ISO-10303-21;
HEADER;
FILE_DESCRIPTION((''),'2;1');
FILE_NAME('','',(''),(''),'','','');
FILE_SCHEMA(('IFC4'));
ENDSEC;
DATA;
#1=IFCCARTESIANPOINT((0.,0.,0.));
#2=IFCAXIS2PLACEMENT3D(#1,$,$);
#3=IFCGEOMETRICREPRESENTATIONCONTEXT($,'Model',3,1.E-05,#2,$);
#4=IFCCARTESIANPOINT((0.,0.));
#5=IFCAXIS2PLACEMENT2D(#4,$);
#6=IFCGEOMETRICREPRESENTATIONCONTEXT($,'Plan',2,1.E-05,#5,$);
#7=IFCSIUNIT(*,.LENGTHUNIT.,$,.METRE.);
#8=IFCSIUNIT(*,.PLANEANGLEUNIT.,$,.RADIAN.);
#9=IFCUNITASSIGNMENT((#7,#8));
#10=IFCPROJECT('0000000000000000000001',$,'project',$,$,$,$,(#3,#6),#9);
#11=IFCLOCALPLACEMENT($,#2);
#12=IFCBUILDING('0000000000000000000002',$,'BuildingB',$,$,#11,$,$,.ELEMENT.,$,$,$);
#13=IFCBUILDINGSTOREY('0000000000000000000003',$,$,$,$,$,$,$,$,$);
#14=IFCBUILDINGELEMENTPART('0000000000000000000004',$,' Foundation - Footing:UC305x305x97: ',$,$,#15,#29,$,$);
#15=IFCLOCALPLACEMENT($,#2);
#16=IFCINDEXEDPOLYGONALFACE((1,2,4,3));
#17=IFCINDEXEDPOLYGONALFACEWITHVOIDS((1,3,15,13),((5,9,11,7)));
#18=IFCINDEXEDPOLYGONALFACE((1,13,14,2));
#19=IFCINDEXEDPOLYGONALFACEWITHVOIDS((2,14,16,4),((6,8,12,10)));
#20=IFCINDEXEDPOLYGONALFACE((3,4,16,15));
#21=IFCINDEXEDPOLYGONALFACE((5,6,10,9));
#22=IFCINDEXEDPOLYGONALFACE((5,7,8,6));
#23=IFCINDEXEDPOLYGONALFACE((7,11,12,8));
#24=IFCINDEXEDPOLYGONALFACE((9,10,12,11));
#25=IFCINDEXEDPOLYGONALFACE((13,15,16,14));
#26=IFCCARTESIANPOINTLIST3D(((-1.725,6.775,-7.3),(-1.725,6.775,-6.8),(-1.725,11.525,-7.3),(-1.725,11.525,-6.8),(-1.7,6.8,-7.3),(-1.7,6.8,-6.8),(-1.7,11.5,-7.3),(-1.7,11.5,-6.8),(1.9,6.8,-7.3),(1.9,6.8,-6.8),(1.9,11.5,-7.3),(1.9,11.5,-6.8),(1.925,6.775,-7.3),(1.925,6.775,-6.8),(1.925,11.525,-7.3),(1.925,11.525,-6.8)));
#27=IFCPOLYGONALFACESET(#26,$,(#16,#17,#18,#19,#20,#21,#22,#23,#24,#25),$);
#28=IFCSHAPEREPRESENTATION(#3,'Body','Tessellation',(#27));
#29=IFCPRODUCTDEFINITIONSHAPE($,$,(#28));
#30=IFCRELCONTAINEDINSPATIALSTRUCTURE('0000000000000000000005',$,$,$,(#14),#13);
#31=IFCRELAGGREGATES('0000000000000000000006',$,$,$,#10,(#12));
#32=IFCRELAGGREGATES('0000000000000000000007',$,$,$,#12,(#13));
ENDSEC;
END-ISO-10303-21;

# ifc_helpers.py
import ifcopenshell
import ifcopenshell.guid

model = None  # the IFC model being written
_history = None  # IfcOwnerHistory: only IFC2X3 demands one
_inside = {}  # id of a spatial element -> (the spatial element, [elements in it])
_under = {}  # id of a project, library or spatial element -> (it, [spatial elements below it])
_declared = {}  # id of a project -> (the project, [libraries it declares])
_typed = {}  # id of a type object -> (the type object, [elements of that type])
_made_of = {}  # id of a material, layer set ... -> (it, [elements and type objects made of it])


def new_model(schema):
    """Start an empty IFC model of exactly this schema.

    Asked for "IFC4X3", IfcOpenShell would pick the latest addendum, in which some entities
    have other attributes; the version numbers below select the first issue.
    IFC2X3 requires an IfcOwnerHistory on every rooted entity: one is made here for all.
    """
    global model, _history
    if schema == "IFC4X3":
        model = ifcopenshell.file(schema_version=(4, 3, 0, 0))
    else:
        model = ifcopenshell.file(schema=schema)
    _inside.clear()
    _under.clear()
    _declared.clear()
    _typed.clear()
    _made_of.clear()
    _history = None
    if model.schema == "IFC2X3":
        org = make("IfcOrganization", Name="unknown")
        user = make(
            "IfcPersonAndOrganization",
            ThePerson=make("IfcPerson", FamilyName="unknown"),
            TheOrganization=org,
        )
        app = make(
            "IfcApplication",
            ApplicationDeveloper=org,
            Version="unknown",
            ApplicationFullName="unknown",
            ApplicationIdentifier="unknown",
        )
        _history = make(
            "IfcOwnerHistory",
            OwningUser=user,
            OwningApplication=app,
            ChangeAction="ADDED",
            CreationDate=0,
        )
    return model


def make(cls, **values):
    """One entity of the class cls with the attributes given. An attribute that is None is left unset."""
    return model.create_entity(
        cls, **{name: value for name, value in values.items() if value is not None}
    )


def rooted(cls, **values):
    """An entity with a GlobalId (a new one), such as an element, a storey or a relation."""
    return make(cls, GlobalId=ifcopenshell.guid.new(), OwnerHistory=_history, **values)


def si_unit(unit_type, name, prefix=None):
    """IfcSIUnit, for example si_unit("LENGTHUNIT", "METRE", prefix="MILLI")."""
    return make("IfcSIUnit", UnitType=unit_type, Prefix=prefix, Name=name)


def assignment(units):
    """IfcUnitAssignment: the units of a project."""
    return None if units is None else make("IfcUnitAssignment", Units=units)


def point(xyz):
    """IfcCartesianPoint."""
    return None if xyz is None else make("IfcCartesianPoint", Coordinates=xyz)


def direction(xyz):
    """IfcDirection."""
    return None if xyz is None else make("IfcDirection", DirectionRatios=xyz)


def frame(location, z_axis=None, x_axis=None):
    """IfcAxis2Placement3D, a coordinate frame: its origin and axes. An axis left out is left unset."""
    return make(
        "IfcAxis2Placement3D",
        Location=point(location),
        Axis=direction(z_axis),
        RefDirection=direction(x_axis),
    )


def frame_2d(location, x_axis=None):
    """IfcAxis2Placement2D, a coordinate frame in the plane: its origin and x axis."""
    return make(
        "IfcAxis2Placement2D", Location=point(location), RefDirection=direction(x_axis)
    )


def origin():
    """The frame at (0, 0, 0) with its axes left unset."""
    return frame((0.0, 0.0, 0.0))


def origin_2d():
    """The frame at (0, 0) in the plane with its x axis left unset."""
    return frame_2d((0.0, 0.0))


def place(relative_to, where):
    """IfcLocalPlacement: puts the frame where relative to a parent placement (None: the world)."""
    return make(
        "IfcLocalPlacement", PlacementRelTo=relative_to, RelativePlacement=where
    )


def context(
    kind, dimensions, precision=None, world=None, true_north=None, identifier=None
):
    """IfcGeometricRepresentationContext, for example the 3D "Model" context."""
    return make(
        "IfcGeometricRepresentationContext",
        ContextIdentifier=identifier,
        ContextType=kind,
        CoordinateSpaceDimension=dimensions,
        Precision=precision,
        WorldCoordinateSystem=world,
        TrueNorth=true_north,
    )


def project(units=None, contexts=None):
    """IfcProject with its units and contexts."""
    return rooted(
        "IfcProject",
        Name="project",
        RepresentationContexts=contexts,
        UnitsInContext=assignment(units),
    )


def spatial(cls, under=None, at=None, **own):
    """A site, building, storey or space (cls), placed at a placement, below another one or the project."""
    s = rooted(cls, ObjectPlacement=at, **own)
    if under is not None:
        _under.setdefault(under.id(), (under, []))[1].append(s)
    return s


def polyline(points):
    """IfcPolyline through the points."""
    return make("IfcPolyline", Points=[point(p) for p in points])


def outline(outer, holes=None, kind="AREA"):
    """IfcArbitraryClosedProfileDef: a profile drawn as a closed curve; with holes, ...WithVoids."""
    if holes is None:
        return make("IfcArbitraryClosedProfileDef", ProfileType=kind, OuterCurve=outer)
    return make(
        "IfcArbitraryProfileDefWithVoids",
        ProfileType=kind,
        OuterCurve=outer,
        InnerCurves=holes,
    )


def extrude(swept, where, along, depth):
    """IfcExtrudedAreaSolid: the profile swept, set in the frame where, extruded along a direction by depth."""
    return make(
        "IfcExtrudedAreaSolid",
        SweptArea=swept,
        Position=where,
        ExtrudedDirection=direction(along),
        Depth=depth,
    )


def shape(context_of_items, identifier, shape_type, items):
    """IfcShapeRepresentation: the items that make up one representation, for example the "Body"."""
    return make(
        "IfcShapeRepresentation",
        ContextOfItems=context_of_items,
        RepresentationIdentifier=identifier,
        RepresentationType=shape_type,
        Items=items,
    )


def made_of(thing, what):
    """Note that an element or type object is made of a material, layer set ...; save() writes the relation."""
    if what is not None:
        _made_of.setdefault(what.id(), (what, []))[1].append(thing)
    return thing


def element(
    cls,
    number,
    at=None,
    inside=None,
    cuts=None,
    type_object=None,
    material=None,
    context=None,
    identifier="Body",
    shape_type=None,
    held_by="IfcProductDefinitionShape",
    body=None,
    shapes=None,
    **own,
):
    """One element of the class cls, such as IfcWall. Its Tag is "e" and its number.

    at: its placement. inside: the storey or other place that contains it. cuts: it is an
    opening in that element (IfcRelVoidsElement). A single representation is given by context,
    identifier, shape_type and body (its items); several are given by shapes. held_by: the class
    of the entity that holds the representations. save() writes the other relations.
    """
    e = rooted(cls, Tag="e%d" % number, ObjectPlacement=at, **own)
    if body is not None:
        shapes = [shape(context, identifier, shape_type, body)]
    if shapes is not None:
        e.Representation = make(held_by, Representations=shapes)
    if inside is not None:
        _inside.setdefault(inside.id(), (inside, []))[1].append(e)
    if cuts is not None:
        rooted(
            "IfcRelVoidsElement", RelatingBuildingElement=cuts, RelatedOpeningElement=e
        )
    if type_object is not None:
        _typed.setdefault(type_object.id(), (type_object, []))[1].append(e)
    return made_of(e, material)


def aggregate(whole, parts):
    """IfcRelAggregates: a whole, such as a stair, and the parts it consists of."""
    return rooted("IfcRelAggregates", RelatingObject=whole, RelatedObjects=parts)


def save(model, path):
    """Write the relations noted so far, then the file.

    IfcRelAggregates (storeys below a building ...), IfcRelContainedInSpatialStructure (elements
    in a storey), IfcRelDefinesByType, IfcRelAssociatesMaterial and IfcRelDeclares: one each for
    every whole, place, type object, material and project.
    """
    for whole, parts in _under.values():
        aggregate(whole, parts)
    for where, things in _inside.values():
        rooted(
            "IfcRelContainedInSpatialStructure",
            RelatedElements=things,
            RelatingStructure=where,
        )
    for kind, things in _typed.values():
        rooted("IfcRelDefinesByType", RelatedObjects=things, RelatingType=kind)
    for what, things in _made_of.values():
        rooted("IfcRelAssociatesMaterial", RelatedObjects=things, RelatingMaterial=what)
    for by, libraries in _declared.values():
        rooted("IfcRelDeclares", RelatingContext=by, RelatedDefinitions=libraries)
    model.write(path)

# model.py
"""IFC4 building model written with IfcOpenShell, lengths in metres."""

from ifc_helpers import new_model, si_unit, origin, origin_2d, place, context, project, spatial, polyline, outline, extrude, element, save


model = new_model("IFC4")

# Units and contexts
model_context = context("Model", 3, precision=1e-05, world=origin())
plan_context = context("Plan", 2, precision=1e-05, world=origin_2d())
ifc_project = project(units=[si_unit("LENGTHUNIT", "METRE"), si_unit("PLANEANGLEUNIT", "RADIAN")], contexts=[model_context, plan_context])

# Building, storey
building_placement = place(None, origin())
building = spatial("IfcBuilding", under=ifc_project, at=building_placement, Name="BuildingB", CompositionType="ELEMENT")
storey = spatial("IfcBuildingStorey", under=building)

# Building element part, opening
building_element_part_1 = element("IfcBuildingElementPart", 1, inside=storey, Name=" Foundation - Footing:UC305x305x97: ", context=model_context, shape_type="SweptSolid", body=[
    extrude(outline(polyline([(1.925, 11.525, -7.3), (-1.725, 11.525, -7.3), (-1.725, 6.775, -7.3), (1.925, 6.775, -7.3), (1.925, 11.525, -7.3)])), None, (0.0, 0.0, 1.0), 0.5),
])
element("IfcOpeningElement", 2, inside=storey, cuts=building_element_part_1, context=model_context, shape_type="SweptSolid", body=[
    extrude(outline(polyline([(1.9, 11.5, -7.3), (-1.7, 11.5, -7.3), (-1.7, 6.8, -7.3), (1.9, 6.8, -7.3), (1.9, 11.5, -7.3)])), None, (0.0, 0.0, 1.0), 0.5),
])

save(model, "model.ifc")
